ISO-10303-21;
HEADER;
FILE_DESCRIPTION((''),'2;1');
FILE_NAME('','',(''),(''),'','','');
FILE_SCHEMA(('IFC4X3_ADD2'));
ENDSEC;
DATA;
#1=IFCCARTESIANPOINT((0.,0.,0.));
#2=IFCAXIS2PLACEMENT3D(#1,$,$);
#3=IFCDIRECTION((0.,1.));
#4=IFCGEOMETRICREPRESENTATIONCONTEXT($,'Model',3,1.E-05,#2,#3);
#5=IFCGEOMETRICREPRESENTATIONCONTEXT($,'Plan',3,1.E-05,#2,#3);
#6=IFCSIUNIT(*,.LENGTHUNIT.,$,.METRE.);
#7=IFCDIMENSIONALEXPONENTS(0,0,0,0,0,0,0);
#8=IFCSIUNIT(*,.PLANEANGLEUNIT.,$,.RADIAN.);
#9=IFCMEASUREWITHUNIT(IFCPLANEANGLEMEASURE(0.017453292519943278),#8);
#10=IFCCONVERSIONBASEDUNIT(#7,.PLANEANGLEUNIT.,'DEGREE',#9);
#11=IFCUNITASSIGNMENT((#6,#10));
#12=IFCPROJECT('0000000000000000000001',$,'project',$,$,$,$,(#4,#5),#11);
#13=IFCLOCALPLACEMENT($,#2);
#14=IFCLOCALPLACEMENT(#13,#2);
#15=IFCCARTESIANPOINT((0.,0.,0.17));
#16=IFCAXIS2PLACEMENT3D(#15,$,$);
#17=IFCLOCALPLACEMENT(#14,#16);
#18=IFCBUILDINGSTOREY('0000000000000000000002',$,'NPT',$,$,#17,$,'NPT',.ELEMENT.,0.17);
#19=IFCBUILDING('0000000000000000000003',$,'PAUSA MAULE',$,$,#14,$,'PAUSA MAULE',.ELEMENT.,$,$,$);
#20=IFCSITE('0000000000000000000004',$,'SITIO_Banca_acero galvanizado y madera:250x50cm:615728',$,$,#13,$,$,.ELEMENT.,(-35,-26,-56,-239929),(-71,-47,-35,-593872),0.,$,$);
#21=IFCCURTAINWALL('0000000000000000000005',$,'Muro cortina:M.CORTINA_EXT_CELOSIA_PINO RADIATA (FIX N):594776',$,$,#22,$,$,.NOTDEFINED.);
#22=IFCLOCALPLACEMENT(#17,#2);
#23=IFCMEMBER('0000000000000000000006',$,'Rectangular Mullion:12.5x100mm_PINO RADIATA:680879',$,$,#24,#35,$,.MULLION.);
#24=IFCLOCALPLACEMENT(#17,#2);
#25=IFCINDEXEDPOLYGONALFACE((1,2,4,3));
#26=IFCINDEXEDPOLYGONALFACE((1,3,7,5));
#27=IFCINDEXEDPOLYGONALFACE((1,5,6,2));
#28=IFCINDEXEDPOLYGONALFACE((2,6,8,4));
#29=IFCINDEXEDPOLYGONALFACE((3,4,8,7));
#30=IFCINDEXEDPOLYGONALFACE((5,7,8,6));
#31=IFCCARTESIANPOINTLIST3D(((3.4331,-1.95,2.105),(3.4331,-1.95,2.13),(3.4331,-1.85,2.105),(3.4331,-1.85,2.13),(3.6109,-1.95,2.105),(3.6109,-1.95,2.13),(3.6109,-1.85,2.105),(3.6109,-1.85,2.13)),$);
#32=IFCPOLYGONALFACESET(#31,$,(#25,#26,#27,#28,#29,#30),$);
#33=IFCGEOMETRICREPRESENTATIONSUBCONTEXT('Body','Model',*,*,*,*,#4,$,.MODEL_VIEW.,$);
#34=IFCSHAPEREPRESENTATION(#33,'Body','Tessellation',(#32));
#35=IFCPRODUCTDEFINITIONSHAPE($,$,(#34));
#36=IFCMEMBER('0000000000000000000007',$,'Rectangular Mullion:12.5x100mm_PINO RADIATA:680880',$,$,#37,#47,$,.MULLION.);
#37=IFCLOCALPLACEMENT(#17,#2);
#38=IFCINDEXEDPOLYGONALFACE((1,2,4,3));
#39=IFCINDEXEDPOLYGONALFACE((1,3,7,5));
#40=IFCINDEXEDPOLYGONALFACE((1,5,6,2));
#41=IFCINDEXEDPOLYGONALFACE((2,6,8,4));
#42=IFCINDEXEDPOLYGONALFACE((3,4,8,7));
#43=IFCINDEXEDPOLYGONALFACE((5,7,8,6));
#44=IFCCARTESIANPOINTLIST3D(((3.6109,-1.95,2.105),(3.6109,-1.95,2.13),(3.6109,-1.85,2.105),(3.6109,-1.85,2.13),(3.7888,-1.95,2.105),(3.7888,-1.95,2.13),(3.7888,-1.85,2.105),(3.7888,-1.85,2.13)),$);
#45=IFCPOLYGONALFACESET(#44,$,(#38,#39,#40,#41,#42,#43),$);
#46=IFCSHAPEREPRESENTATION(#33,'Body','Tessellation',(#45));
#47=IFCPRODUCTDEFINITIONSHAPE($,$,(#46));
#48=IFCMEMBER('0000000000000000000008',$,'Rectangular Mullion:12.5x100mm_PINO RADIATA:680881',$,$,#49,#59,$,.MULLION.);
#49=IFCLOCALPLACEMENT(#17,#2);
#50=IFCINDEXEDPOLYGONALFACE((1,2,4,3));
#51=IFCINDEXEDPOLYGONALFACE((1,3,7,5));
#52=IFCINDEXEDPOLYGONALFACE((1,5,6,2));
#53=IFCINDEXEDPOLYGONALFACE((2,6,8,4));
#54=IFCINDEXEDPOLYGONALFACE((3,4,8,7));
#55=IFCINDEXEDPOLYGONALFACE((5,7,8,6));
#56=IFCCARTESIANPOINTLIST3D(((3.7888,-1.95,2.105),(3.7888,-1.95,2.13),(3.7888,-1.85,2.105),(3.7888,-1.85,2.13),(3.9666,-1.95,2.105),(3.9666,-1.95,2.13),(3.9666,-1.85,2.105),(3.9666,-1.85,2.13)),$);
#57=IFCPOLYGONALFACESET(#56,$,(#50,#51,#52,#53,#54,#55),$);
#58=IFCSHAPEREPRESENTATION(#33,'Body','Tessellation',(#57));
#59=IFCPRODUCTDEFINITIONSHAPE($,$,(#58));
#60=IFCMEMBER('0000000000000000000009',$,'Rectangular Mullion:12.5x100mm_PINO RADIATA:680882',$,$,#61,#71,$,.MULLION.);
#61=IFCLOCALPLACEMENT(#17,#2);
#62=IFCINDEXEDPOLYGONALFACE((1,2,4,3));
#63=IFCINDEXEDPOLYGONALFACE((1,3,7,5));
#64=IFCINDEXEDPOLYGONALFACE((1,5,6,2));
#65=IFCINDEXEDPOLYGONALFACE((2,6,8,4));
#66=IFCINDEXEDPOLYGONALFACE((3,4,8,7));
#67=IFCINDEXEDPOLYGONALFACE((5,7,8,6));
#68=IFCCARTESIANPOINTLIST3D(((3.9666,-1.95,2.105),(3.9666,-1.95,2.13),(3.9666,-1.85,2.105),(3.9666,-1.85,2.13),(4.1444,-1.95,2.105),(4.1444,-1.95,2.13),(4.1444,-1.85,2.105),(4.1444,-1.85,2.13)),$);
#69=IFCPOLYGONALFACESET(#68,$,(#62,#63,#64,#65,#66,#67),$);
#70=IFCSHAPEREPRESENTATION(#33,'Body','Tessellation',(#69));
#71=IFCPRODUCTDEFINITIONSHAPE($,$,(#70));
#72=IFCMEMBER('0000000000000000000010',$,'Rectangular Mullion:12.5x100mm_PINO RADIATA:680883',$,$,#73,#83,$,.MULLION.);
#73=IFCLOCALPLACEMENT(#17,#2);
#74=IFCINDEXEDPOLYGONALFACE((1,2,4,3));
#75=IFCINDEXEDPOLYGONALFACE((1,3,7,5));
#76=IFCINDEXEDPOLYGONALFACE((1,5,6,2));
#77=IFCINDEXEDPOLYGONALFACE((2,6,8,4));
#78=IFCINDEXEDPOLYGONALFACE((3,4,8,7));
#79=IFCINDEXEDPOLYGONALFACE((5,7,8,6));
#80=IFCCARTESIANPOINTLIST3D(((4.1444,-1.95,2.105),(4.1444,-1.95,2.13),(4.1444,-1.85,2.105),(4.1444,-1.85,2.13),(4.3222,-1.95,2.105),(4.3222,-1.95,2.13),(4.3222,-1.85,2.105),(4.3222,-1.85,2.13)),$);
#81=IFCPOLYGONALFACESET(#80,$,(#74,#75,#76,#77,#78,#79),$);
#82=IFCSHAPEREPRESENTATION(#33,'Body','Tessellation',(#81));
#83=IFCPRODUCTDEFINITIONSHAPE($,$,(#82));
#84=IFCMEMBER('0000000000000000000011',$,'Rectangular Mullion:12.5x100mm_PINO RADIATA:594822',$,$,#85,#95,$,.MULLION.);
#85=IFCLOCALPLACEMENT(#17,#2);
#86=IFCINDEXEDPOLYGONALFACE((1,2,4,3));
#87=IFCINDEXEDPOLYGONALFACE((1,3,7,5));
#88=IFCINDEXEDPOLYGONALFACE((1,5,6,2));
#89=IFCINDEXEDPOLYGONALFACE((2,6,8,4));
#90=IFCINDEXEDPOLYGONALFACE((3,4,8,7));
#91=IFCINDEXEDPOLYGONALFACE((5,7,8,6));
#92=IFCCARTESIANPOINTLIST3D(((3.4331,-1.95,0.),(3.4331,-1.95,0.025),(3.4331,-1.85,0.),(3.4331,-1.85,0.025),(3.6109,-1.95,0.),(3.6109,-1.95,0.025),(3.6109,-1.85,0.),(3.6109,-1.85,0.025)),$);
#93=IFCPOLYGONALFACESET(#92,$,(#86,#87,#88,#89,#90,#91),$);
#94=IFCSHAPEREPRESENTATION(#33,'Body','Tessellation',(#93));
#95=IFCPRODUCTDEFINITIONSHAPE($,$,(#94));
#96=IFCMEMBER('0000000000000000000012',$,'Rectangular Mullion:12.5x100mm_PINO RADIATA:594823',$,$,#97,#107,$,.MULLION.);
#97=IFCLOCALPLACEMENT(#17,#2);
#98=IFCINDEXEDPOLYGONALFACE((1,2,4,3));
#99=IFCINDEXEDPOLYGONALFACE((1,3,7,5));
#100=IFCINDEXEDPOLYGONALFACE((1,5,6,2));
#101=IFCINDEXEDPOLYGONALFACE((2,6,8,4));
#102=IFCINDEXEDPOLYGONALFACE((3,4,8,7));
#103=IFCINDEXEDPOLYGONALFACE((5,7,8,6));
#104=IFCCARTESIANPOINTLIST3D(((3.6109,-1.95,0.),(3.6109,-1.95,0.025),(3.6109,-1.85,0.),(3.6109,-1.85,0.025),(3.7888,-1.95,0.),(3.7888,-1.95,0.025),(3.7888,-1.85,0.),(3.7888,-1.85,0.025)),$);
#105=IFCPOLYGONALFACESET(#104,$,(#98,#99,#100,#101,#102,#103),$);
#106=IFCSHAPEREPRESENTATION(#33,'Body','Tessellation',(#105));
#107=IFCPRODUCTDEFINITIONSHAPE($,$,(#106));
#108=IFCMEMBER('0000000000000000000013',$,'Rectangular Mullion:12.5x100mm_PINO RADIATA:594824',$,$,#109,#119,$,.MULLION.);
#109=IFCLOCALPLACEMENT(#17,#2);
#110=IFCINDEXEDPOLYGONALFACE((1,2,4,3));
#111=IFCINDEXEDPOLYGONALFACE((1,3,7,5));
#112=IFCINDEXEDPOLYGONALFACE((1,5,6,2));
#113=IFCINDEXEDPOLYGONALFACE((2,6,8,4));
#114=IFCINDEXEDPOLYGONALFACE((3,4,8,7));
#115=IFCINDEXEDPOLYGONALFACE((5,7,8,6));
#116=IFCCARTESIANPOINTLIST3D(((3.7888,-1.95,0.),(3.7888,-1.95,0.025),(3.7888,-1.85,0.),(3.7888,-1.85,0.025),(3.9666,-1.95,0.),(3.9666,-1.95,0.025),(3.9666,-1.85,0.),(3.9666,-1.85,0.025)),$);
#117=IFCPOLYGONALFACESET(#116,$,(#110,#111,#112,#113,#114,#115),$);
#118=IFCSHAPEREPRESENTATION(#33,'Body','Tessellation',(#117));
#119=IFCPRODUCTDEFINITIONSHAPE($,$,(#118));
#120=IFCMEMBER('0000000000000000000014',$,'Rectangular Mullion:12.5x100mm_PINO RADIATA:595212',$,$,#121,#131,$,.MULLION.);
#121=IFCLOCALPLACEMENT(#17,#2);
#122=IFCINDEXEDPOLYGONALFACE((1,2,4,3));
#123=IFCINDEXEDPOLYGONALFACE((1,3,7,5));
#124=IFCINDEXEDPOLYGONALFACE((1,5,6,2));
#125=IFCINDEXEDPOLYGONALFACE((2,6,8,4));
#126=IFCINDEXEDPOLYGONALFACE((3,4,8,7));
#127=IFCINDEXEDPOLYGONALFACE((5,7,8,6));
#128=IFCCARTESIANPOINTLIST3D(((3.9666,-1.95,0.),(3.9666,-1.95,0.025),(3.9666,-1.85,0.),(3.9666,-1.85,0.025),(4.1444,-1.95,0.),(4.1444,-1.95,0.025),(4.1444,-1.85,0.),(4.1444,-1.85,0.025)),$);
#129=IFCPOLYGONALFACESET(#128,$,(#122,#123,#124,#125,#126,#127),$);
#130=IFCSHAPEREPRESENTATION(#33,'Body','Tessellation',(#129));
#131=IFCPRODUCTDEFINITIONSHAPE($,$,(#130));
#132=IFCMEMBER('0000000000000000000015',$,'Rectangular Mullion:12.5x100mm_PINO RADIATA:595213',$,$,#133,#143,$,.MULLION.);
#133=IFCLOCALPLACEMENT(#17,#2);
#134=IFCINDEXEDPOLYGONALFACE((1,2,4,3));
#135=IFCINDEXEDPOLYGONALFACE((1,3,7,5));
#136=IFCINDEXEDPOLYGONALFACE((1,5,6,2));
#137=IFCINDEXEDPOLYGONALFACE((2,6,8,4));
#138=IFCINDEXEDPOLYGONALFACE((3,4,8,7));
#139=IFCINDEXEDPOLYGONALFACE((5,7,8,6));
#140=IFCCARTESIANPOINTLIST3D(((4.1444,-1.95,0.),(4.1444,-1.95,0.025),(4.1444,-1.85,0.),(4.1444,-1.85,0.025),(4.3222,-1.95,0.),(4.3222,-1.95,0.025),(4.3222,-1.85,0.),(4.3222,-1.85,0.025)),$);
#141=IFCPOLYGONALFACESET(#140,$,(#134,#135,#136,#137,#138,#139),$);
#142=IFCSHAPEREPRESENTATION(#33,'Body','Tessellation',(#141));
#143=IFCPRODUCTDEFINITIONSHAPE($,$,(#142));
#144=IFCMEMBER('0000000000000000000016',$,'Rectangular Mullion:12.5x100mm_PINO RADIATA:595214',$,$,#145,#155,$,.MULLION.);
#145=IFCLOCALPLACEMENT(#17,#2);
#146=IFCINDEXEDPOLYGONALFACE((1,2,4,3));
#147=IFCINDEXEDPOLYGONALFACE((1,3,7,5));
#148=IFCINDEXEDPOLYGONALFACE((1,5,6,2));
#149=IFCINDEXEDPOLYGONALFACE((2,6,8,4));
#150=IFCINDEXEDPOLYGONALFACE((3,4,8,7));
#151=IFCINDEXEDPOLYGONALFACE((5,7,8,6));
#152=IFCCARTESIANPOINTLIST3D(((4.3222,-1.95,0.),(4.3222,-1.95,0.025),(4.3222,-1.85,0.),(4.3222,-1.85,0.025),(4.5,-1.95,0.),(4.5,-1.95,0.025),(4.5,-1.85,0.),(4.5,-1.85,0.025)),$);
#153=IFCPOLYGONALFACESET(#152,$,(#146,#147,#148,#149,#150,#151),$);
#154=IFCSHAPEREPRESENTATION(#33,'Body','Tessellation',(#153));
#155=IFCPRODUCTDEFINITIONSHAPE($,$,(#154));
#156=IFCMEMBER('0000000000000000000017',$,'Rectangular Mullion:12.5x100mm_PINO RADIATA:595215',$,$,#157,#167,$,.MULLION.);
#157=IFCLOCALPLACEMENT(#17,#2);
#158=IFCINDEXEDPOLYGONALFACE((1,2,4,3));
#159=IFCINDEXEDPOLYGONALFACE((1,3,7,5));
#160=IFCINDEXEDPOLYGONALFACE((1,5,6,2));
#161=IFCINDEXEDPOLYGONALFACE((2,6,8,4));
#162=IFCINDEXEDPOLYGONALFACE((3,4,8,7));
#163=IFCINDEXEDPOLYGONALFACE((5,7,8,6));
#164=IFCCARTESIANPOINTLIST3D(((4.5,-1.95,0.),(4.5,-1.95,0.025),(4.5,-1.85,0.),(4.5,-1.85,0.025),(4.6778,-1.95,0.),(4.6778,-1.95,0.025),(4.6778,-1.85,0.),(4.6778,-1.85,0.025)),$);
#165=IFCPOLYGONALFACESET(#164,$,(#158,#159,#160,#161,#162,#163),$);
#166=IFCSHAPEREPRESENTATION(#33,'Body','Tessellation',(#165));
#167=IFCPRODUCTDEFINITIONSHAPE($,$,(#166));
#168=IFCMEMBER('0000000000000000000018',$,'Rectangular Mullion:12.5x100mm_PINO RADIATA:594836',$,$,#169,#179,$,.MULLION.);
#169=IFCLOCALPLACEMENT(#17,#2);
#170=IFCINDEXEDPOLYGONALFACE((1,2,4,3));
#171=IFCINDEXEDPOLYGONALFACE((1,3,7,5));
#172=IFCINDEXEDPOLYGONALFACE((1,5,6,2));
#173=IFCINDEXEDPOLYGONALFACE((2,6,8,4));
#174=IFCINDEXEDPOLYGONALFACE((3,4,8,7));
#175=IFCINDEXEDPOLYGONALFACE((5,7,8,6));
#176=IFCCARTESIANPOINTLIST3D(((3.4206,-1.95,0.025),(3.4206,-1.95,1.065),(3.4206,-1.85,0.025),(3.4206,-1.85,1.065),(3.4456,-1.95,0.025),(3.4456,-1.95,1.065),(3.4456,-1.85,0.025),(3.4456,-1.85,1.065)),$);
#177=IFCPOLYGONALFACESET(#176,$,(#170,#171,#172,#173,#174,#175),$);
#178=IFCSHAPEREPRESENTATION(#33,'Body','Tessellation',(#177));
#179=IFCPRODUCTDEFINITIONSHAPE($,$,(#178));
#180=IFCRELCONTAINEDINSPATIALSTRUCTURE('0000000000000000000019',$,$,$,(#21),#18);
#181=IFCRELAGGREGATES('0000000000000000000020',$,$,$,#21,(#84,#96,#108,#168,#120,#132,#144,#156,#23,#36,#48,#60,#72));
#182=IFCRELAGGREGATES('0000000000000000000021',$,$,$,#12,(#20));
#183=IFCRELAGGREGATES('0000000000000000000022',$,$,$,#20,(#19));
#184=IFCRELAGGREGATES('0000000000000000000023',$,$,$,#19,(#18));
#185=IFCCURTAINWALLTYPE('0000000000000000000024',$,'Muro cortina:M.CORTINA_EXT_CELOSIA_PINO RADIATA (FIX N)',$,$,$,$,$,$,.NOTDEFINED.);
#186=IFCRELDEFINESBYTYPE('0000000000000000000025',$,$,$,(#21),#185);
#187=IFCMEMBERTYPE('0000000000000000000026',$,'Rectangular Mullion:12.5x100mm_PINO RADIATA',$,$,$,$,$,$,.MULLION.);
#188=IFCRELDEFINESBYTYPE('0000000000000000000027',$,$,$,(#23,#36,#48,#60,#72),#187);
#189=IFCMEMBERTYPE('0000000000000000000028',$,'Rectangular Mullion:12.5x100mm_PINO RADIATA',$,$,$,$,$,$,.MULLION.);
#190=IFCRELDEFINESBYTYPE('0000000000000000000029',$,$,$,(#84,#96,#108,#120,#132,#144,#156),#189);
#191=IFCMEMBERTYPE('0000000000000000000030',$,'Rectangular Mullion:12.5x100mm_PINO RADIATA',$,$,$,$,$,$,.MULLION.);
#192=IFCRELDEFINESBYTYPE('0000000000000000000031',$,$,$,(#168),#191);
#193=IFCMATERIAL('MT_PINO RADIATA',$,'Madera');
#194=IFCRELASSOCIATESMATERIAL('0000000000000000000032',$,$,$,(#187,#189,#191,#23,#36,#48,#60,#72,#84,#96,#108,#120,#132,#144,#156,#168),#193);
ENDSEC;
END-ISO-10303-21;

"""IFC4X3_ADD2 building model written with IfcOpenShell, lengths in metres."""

from ifc_helpers import new_model, entity, si_unit, converted_unit, direction, frame, frame_2d, origin, place, context, subcontext, project, spatial, rectangle, extrude, source, transform, mapped, material, material_profile, profile_set, profile_usage, type_object, type_shapes, element, aggregate, save


model = new_model("IFC4X3_ADD2")

# Units and contexts
model_context = context("Model", 3, precision=1e-05, world=origin(), true_north=direction((0.0, 1.0)))
plan_context = context("Plan", 3, precision=1e-05, world=origin(), true_north=direction((0.0, 1.0)))
body_context = subcontext(model_context, "Body", "Model", "MODEL_VIEW")
ifc_project = project(units=[si_unit("LENGTHUNIT", "METRE"), converted_unit("PLANEANGLEUNIT", "DEGREE", entity("IfcPlaneAngleMeasure", 0.017453292519943278), si_unit("PLANEANGLEUNIT", "RADIAN"), dimensions=[0, 0, 0, 0, 0, 0, 0])], contexts=[model_context, plan_context])

# Site, building, storey
site_placement = place(None, origin())
site = spatial("IfcSite", under=ifc_project, at=site_placement, Name="SITIO_Banca_acero galvanizado y madera:250x50cm:615728", CompositionType="ELEMENT", RefLatitude=(-35, -26, -56, -239929), RefLongitude=(-71, -47, -35, -593872), RefElevation=0.0)
building_placement = place(site_placement, origin())
building = spatial("IfcBuilding", under=site, at=building_placement, Name="PAUSA MAULE", LongName="PAUSA MAULE", CompositionType="ELEMENT")
storey_placement = place(building_placement, frame((0.0, 0.0, 0.17)))
storey = spatial("IfcBuildingStorey", under=building, at=storey_placement, Name="NPT", LongName="NPT", CompositionType="ELEMENT", Elevation=0.17)

# Curtain wall, members
curtain_wall_type = type_object("IfcCurtainWallType", Name="Muro cortina:M.CORTINA_EXT_CELOSIA_PINO RADIATA (FIX N)", PredefinedType="NOTDEFINED")
curtain_wall_placement = place(storey_placement, frame((0.0, 0.0, -0.17)))
curtain_wall = element("IfcCurtainWall", 1, at=curtain_wall_placement, inside=storey, type_object=curtain_wall_type, Name="Muro cortina:M.CORTINA_EXT_CELOSIA_PINO RADIATA (FIX N):594776", PredefinedType="NOTDEFINED")
ifc_material = material(Name="MT_PINO RADIATA", Category="Madera")
ifc_material_profile = material_profile(ifc_material, rectangle(XDim=0.025, YDim=0.1, at=frame_2d((0.0, 0.0), x_axis=(1.0, 0.0))), Name="12.5x100mm_PINO RADIATA")
ifc_profile_set = profile_set([ifc_material_profile], Name="12.5x100mm_PINO RADIATA")
ifc_profile_usage = profile_usage(ifc_profile_set)
member_type_1 = type_object("IfcMemberType", Name="Rectangular Mullion:12.5x100mm_PINO RADIATA", PredefinedType="MULLION", material=ifc_profile_set)
shared_shape_1 = source(origin(), body_context, "Body", "SweptSolid", [
    extrude(rectangle(XDim=0.025, YDim=0.1, at=frame_2d((0.0, 0.0), x_axis=(1.0, 0.0))), frame((-0.0125, 0.0, -0.1778), z_axis=(0.0, 0.0, 1.0), x_axis=(-1.0, 0.0, 0.0)), (0.0, 0.0, 1.0), 0.1778),
])
type_shapes(member_type_1, [shared_shape_1])
member_1_placement = place(curtain_wall_placement, frame((3.6109, -1.9, 2.3), z_axis=(1.0, 0.0, 0.0), x_axis=(0.0, 0.0, 1.0)))
member_1 = element("IfcMember", 2, at=member_1_placement, type_object=member_type_1, material=ifc_profile_usage, Name="Rectangular Mullion:12.5x100mm_PINO RADIATA:680879", PredefinedType="MULLION", context=body_context, shape_type="MappedRepresentation", body=[
    mapped(shared_shape_1, transform((0.0, 0.0, 0.0), scale=1.0)),
])
member_2_placement = place(curtain_wall_placement, frame((3.7888, -1.9, 2.3), z_axis=(1.0, 0.0, 0.0), x_axis=(0.0, 0.0, 1.0)))
member_2 = element("IfcMember", 3, at=member_2_placement, type_object=member_type_1, material=ifc_profile_usage, Name="Rectangular Mullion:12.5x100mm_PINO RADIATA:680880", PredefinedType="MULLION", context=body_context, shape_type="MappedRepresentation", body=[
    mapped(shared_shape_1, transform((0.0, 0.0, 0.0), scale=1.0)),
])
member_3_placement = place(curtain_wall_placement, frame((3.9666, -1.9, 2.3), z_axis=(1.0, 0.0, 0.0), x_axis=(0.0, 0.0, 1.0)))
member_3 = element("IfcMember", 4, at=member_3_placement, type_object=member_type_1, material=ifc_profile_usage, Name="Rectangular Mullion:12.5x100mm_PINO RADIATA:680881", PredefinedType="MULLION", context=body_context, shape_type="MappedRepresentation", body=[
    mapped(shared_shape_1, transform((0.0, 0.0, 0.0), scale=1.0)),
])
member_4_placement = place(curtain_wall_placement, frame((4.1444, -1.9, 2.3), z_axis=(1.0, 0.0, 0.0), x_axis=(0.0, 0.0, 1.0)))
member_4 = element("IfcMember", 5, at=member_4_placement, type_object=member_type_1, material=ifc_profile_usage, Name="Rectangular Mullion:12.5x100mm_PINO RADIATA:680882", PredefinedType="MULLION", context=body_context, shape_type="MappedRepresentation", body=[
    mapped(shared_shape_1, transform((0.0, 0.0, 0.0), scale=1.0)),
])
member_5_placement = place(curtain_wall_placement, frame((4.3222, -1.9, 2.3), z_axis=(1.0, 0.0, 0.0), x_axis=(0.0, 0.0, 1.0)))
member_5 = element("IfcMember", 6, at=member_5_placement, type_object=member_type_1, material=ifc_profile_usage, Name="Rectangular Mullion:12.5x100mm_PINO RADIATA:680883", PredefinedType="MULLION", context=body_context, shape_type="MappedRepresentation", body=[
    mapped(shared_shape_1, transform((0.0, 0.0, 0.0), scale=1.0)),
])
member_type_2 = type_object("IfcMemberType", Name="Rectangular Mullion:12.5x100mm_PINO RADIATA", PredefinedType="MULLION", material=ifc_profile_set)
shared_shape_2 = source(origin(), body_context, "Body", "SweptSolid", [
    extrude(rectangle(XDim=0.025, YDim=0.1, at=frame_2d((0.0, 0.0), x_axis=(1.0, 0.0))), frame((-0.0125, 0.0, -0.1778), z_axis=(0.0, 0.0, 1.0), x_axis=(-1.0, 0.0, 0.0)), (0.0, 0.0, 1.0), 0.1778),
])
type_shapes(member_type_2, [shared_shape_2])
member_6_placement = place(curtain_wall_placement, frame((3.4331, -1.9, 0.17), z_axis=(-1.0, 0.0, 0.0), x_axis=(0.0, 0.0, -1.0)))
member_6 = element("IfcMember", 7, at=member_6_placement, type_object=member_type_2, material=ifc_profile_usage, Name="Rectangular Mullion:12.5x100mm_PINO RADIATA:594822", PredefinedType="MULLION", context=body_context, shape_type="MappedRepresentation", body=[
    mapped(shared_shape_2, transform((0.0, 0.0, 0.0), scale=1.0)),
])
member_7_placement = place(curtain_wall_placement, frame((3.6109, -1.9, 0.17), z_axis=(-1.0, 0.0, 0.0), x_axis=(0.0, 0.0, -1.0)))
member_7 = element("IfcMember", 8, at=member_7_placement, type_object=member_type_2, material=ifc_profile_usage, Name="Rectangular Mullion:12.5x100mm_PINO RADIATA:594823", PredefinedType="MULLION", context=body_context, shape_type="MappedRepresentation", body=[
    mapped(shared_shape_2, transform((0.0, 0.0, 0.0), scale=1.0)),
])
member_8_placement = place(curtain_wall_placement, frame((3.7888, -1.9, 0.17), z_axis=(-1.0, 0.0, 0.0), x_axis=(0.0, 0.0, -1.0)))
member_8 = element("IfcMember", 9, at=member_8_placement, type_object=member_type_2, material=ifc_profile_usage, Name="Rectangular Mullion:12.5x100mm_PINO RADIATA:594824", PredefinedType="MULLION", context=body_context, shape_type="MappedRepresentation", body=[
    mapped(shared_shape_2, transform((0.0, 0.0, 0.0), scale=1.0)),
])
member_9_placement = place(curtain_wall_placement, frame((3.9666, -1.9, 0.17), z_axis=(-1.0, 0.0, 0.0), x_axis=(0.0, 0.0, -1.0)))
member_9 = element("IfcMember", 10, at=member_9_placement, type_object=member_type_2, material=ifc_profile_usage, Name="Rectangular Mullion:12.5x100mm_PINO RADIATA:595212", PredefinedType="MULLION", context=body_context, shape_type="MappedRepresentation", body=[
    mapped(shared_shape_2, transform((0.0, 0.0, 0.0), scale=1.0)),
])
member_10_placement = place(curtain_wall_placement, frame((4.1444, -1.9, 0.17), z_axis=(-1.0, 0.0, 0.0), x_axis=(0.0, 0.0, -1.0)))
member_10 = element("IfcMember", 11, at=member_10_placement, type_object=member_type_2, material=ifc_profile_usage, Name="Rectangular Mullion:12.5x100mm_PINO RADIATA:595213", PredefinedType="MULLION", context=body_context, shape_type="MappedRepresentation", body=[
    mapped(shared_shape_2, transform((0.0, 0.0, 0.0), scale=1.0)),
])
member_11_placement = place(curtain_wall_placement, frame((4.3222, -1.9, 0.17), z_axis=(-1.0, 0.0, 0.0), x_axis=(0.0, 0.0, -1.0)))
member_11 = element("IfcMember", 12, at=member_11_placement, type_object=member_type_2, material=ifc_profile_usage, Name="Rectangular Mullion:12.5x100mm_PINO RADIATA:595214", PredefinedType="MULLION", context=body_context, shape_type="MappedRepresentation", body=[
    mapped(shared_shape_2, transform((0.0, 0.0, 0.0), scale=1.0)),
])
member_12_placement = place(curtain_wall_placement, frame((4.5, -1.9, 0.17), z_axis=(-1.0, 0.0, 0.0), x_axis=(0.0, 0.0, -1.0)))
member_12 = element("IfcMember", 13, at=member_12_placement, type_object=member_type_2, material=ifc_profile_usage, Name="Rectangular Mullion:12.5x100mm_PINO RADIATA:595215", PredefinedType="MULLION", context=body_context, shape_type="MappedRepresentation", body=[
    mapped(shared_shape_2, transform((0.0, 0.0, 0.0), scale=1.0)),
])
member_type_3 = type_object("IfcMemberType", Name="Rectangular Mullion:12.5x100mm_PINO RADIATA", PredefinedType="MULLION", material=ifc_profile_set)
shared_shape_3 = source(origin(), body_context, "Body", "SweptSolid", [
    extrude(rectangle(XDim=0.025, YDim=0.1, at=frame_2d((0.0, 0.0), x_axis=(1.0, 0.0))), frame((0.0, 0.0, -1.04), z_axis=(0.0, 0.0, 1.0), x_axis=(-1.0, 0.0, 0.0)), (0.0, 0.0, 1.0), 1.04),
])
type_shapes(member_type_3, [shared_shape_3])
member_13_placement = place(curtain_wall_placement, frame((3.4331, -1.9, 0.195), z_axis=(0.0, 0.0, -1.0), x_axis=(1.0, 0.0, 0.0)))
member_13 = element("IfcMember", 14, at=member_13_placement, type_object=member_type_3, material=ifc_profile_usage, Name="Rectangular Mullion:12.5x100mm_PINO RADIATA:594836", PredefinedType="MULLION", context=body_context, shape_type="MappedRepresentation", body=[
    mapped(shared_shape_3, transform((0.0, 0.0, 0.0), scale=1.0)),
])
aggregate(curtain_wall, [member_6, member_7, member_8, member_13, member_9, member_10, member_11, member_12, member_1, member_2, member_3, member_4, member_5])

save(model, "model.ifc")
